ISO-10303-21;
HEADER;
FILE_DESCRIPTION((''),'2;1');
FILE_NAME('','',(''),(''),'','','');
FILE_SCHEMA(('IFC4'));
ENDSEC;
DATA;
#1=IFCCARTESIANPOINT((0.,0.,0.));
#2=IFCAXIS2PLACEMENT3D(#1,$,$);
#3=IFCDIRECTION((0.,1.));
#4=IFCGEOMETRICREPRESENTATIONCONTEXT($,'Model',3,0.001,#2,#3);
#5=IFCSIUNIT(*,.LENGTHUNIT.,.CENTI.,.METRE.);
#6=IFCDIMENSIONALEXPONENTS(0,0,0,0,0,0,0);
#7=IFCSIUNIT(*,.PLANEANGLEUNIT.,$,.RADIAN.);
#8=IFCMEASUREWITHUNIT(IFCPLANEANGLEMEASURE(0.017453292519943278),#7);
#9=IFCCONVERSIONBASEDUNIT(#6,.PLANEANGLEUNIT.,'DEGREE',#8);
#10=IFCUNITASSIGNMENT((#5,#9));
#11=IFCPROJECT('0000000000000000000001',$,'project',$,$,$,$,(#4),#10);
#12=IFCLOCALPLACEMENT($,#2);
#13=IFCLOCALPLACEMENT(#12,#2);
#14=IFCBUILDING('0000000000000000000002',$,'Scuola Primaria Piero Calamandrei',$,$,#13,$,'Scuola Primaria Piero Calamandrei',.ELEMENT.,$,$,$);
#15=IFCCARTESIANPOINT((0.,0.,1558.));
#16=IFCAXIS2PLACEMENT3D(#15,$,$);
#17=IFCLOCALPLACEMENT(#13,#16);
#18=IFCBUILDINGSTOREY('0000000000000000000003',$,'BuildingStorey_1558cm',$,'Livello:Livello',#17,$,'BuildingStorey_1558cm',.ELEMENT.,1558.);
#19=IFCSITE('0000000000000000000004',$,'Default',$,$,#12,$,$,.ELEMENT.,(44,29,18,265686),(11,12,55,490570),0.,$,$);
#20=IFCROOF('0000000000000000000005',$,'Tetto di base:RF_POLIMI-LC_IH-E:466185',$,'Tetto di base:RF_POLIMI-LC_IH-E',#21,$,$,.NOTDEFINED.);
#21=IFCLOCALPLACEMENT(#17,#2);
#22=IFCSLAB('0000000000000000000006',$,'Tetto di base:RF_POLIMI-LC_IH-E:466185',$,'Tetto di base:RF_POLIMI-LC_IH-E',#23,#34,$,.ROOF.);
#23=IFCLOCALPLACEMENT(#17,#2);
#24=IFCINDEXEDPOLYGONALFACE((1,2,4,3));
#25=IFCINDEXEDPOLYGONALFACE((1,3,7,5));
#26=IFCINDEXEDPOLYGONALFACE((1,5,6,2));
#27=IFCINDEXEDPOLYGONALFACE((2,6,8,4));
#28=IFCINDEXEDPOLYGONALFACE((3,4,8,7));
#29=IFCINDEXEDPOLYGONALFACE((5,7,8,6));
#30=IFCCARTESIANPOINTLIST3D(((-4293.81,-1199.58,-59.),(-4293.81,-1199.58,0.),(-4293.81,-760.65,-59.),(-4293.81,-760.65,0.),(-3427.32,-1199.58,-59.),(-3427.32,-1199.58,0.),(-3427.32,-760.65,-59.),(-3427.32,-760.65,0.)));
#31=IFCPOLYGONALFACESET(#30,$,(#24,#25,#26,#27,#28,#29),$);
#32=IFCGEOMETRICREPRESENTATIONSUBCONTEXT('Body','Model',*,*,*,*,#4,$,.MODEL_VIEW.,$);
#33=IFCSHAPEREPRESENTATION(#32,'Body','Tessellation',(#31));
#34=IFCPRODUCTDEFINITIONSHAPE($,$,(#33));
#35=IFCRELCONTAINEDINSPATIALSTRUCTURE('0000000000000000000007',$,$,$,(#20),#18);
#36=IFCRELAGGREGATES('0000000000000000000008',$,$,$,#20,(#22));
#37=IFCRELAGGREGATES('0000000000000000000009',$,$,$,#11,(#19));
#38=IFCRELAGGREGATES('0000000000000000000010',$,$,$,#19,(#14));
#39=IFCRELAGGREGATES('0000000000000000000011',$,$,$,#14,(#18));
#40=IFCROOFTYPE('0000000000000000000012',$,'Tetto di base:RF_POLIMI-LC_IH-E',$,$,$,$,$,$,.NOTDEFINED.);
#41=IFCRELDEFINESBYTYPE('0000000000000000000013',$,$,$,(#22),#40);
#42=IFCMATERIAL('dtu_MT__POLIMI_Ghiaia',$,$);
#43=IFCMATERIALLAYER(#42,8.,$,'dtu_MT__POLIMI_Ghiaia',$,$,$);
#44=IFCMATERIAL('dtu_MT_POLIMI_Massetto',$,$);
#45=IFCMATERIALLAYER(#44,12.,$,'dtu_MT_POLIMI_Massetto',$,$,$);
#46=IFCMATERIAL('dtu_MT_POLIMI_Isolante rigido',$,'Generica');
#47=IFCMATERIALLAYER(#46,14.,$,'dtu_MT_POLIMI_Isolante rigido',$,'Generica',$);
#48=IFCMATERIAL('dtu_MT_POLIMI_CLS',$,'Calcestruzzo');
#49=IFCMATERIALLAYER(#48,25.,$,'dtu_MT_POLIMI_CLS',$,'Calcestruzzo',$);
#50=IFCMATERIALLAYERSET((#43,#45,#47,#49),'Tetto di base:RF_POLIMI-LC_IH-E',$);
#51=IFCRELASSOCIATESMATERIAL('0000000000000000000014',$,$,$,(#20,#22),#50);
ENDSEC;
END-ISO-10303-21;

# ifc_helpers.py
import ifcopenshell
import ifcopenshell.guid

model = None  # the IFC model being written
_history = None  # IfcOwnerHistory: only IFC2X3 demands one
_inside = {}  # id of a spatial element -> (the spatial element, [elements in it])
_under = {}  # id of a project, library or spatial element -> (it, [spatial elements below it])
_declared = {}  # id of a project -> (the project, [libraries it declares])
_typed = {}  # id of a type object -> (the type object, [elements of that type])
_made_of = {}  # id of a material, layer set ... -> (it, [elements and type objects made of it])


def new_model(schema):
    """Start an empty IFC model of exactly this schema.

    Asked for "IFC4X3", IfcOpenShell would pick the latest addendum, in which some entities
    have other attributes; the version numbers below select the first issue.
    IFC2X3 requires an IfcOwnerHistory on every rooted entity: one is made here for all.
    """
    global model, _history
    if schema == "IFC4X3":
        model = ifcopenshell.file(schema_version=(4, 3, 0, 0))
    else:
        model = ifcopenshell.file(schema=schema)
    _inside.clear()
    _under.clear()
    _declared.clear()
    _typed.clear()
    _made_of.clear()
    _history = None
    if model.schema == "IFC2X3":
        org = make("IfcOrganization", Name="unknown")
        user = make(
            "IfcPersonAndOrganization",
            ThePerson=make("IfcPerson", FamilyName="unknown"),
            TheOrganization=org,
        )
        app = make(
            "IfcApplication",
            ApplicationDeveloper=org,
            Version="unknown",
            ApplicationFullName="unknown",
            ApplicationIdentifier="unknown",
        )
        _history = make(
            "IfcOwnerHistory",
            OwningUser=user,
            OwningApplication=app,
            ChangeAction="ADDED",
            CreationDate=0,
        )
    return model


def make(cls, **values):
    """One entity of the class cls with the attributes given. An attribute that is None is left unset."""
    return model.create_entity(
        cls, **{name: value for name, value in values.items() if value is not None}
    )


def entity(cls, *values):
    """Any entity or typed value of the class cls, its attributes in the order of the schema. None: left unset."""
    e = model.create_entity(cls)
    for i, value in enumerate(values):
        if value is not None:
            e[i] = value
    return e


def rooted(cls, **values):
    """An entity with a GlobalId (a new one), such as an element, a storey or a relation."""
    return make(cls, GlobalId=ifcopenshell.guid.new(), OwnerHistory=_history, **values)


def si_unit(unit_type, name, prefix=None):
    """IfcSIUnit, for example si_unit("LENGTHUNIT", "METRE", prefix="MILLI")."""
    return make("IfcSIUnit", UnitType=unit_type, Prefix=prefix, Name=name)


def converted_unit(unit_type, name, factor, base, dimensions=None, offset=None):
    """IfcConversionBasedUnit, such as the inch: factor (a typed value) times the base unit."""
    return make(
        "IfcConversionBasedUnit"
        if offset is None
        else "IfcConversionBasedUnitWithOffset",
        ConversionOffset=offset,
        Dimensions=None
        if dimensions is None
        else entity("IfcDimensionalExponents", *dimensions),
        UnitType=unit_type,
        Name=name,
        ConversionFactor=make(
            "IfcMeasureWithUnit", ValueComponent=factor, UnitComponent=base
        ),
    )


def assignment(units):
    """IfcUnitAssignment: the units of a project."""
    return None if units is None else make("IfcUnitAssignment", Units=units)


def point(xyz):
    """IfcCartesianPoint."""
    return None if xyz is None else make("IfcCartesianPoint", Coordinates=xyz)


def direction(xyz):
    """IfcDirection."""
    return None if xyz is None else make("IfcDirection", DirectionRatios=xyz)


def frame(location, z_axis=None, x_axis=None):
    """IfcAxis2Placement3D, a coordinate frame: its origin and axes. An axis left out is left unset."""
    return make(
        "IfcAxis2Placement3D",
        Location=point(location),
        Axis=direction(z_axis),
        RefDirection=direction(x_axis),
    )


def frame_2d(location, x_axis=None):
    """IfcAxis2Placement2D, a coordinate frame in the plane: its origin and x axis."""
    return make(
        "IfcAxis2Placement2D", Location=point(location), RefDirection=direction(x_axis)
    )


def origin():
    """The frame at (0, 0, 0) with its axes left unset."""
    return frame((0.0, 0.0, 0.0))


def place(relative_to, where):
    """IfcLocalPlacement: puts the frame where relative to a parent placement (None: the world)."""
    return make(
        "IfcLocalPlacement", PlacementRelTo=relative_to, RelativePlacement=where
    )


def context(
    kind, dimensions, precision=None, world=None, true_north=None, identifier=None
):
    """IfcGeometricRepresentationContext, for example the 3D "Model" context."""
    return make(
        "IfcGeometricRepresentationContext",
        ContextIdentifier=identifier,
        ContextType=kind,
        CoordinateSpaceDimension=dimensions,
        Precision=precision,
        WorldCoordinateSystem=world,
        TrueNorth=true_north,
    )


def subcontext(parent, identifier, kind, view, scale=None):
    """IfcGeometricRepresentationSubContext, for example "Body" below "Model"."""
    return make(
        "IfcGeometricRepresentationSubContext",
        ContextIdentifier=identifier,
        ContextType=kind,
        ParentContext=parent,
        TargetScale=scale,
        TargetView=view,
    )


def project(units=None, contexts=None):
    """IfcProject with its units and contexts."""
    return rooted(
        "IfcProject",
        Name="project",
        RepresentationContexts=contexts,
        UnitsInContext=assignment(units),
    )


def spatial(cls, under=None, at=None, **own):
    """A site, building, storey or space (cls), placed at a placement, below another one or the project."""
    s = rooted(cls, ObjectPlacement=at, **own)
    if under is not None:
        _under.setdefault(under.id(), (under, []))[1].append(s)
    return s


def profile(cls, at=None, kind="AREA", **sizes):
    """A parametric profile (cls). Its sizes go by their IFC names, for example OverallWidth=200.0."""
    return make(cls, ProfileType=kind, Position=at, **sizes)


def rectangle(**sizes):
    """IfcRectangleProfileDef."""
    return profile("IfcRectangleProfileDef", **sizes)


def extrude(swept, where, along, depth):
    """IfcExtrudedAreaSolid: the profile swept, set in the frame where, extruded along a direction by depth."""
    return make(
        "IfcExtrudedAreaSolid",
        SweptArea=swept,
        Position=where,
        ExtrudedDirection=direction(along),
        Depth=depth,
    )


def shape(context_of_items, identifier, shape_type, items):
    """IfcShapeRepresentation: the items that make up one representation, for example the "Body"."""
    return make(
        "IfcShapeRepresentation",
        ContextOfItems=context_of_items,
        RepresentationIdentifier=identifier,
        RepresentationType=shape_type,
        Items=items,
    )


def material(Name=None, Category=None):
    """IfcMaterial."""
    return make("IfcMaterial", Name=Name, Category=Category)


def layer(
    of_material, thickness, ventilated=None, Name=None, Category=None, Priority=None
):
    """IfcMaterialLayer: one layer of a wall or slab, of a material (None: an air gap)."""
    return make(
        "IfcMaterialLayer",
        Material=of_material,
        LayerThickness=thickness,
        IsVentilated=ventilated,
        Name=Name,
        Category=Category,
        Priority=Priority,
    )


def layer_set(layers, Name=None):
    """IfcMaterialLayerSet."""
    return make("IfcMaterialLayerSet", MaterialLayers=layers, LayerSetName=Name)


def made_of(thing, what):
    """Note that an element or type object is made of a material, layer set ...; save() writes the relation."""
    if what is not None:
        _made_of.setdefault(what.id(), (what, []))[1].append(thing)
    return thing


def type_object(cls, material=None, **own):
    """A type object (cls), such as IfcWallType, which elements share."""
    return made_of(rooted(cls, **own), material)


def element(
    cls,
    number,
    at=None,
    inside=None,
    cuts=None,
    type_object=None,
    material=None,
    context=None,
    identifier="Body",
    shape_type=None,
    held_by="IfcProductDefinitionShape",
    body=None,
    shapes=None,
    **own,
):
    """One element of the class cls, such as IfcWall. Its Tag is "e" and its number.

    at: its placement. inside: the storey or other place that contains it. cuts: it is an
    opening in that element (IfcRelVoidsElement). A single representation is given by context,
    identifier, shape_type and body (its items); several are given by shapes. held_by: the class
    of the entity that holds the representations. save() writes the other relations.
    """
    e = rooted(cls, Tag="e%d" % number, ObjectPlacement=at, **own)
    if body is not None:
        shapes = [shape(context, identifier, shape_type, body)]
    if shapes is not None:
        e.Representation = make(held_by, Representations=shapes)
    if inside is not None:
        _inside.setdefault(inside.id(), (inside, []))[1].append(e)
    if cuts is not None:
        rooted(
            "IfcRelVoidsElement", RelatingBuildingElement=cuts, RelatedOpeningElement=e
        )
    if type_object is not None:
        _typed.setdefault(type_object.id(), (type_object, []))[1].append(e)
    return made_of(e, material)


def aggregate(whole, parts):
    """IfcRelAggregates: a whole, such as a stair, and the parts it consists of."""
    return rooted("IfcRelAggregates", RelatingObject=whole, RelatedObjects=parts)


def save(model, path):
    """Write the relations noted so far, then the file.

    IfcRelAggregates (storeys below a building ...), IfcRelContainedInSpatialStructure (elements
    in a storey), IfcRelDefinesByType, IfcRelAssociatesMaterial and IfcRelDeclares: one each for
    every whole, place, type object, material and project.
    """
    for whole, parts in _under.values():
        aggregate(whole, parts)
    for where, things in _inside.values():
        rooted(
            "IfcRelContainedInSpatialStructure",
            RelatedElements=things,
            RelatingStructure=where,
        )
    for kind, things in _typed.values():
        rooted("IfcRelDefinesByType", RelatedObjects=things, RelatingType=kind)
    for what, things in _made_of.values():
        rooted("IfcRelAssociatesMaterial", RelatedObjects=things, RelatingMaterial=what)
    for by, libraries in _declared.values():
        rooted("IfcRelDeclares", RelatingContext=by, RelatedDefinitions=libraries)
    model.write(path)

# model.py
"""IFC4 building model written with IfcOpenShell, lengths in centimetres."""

from ifc_helpers import new_model, entity, si_unit, converted_unit, direction, frame, frame_2d, origin, place, context, subcontext, project, spatial, rectangle, extrude, material, layer, layer_set, type_object, element, aggregate, save


model = new_model("IFC4")

# Units and contexts
model_context = context("Model", 3, precision=0.001, world=origin(), true_north=direction((0.0, 1.0)))
body_context = subcontext(model_context, "Body", "Model", "MODEL_VIEW")
ifc_project = project(units=[si_unit("LENGTHUNIT", "METRE", prefix="CENTI"), converted_unit("PLANEANGLEUNIT", "DEGREE", entity("IfcPlaneAngleMeasure", 0.017453292519943278), si_unit("PLANEANGLEUNIT", "RADIAN"), dimensions=[0, 0, 0, 0, 0, 0, 0])], contexts=[model_context])

# Site, building, storey
site_placement = place(None, origin())
site = spatial("IfcSite", under=ifc_project, at=site_placement, Name="Default", CompositionType="ELEMENT", RefLatitude=(44, 29, 18, 265686), RefLongitude=(11, 12, 55, 490570), RefElevation=0.0)
building_placement = place(site_placement, origin())
building = spatial("IfcBuilding", under=site, at=building_placement, Name="Scuola Primaria Piero Calamandrei", LongName="Scuola Primaria Piero Calamandrei", CompositionType="ELEMENT")
storey_placement = place(building_placement, frame((0.0, 0.0, 1558.0)))
storey = spatial("IfcBuildingStorey", under=building, at=storey_placement, Name="BuildingStorey_1558cm", ObjectType="Livello:Livello", LongName="BuildingStorey_1558cm", CompositionType="ELEMENT", Elevation=1558.0)

# Roof, slab
ifc_material_1 = material(Name="dtu_MT__POLIMI_Ghiaia")
ifc_layer_1 = layer(ifc_material_1, 8.0, Name="dtu_MT__POLIMI_Ghiaia")
ifc_material_2 = material(Name="dtu_MT_POLIMI_Massetto")
ifc_layer_2 = layer(ifc_material_2, 12.0, Name="dtu_MT_POLIMI_Massetto")
ifc_material_3 = material(Name="dtu_MT_POLIMI_Isolante rigido", Category="Generica")
ifc_layer_3 = layer(ifc_material_3, 14.0, Name="dtu_MT_POLIMI_Isolante rigido", Category="Generica")
ifc_material_4 = material(Name="dtu_MT_POLIMI_CLS", Category="Calcestruzzo")
ifc_layer_4 = layer(ifc_material_4, 25.0, Name="dtu_MT_POLIMI_CLS", Category="Calcestruzzo")
ifc_layer_set = layer_set([ifc_layer_1, ifc_layer_2, ifc_layer_3, ifc_layer_4], Name="Tetto di base:RF_POLIMI-LC_IH-E")
roof_placement = place(storey_placement, frame((-4293.81, -1199.58, -59.0)))
roof = element("IfcRoof", 1, at=roof_placement, inside=storey, material=ifc_layer_set, Name="Tetto di base:RF_POLIMI-LC_IH-E:466185", ObjectType="Tetto di base:RF_POLIMI-LC_IH-E", PredefinedType="NOTDEFINED")
roof_type = type_object("IfcRoofType", Name="Tetto di base:RF_POLIMI-LC_IH-E", PredefinedType="NOTDEFINED")
slab_placement = place(roof_placement, origin())
slab = element("IfcSlab", 2, at=slab_placement, type_object=roof_type, material=ifc_layer_set, Name="Tetto di base:RF_POLIMI-LC_IH-E:466185", ObjectType="Tetto di base:RF_POLIMI-LC_IH-E", PredefinedType="ROOF", context=body_context, shape_type="SweptSolid", body=[
    extrude(rectangle(XDim=438.92, YDim=866.49, at=frame_2d((0.0, 0.0), x_axis=(0.0, 1.0))), frame((433.24, 219.46, 0.0)), (0.0, 0.0, 1.0), 59.0),
])
aggregate(roof, [slab])

save(model, "model.ifc")
